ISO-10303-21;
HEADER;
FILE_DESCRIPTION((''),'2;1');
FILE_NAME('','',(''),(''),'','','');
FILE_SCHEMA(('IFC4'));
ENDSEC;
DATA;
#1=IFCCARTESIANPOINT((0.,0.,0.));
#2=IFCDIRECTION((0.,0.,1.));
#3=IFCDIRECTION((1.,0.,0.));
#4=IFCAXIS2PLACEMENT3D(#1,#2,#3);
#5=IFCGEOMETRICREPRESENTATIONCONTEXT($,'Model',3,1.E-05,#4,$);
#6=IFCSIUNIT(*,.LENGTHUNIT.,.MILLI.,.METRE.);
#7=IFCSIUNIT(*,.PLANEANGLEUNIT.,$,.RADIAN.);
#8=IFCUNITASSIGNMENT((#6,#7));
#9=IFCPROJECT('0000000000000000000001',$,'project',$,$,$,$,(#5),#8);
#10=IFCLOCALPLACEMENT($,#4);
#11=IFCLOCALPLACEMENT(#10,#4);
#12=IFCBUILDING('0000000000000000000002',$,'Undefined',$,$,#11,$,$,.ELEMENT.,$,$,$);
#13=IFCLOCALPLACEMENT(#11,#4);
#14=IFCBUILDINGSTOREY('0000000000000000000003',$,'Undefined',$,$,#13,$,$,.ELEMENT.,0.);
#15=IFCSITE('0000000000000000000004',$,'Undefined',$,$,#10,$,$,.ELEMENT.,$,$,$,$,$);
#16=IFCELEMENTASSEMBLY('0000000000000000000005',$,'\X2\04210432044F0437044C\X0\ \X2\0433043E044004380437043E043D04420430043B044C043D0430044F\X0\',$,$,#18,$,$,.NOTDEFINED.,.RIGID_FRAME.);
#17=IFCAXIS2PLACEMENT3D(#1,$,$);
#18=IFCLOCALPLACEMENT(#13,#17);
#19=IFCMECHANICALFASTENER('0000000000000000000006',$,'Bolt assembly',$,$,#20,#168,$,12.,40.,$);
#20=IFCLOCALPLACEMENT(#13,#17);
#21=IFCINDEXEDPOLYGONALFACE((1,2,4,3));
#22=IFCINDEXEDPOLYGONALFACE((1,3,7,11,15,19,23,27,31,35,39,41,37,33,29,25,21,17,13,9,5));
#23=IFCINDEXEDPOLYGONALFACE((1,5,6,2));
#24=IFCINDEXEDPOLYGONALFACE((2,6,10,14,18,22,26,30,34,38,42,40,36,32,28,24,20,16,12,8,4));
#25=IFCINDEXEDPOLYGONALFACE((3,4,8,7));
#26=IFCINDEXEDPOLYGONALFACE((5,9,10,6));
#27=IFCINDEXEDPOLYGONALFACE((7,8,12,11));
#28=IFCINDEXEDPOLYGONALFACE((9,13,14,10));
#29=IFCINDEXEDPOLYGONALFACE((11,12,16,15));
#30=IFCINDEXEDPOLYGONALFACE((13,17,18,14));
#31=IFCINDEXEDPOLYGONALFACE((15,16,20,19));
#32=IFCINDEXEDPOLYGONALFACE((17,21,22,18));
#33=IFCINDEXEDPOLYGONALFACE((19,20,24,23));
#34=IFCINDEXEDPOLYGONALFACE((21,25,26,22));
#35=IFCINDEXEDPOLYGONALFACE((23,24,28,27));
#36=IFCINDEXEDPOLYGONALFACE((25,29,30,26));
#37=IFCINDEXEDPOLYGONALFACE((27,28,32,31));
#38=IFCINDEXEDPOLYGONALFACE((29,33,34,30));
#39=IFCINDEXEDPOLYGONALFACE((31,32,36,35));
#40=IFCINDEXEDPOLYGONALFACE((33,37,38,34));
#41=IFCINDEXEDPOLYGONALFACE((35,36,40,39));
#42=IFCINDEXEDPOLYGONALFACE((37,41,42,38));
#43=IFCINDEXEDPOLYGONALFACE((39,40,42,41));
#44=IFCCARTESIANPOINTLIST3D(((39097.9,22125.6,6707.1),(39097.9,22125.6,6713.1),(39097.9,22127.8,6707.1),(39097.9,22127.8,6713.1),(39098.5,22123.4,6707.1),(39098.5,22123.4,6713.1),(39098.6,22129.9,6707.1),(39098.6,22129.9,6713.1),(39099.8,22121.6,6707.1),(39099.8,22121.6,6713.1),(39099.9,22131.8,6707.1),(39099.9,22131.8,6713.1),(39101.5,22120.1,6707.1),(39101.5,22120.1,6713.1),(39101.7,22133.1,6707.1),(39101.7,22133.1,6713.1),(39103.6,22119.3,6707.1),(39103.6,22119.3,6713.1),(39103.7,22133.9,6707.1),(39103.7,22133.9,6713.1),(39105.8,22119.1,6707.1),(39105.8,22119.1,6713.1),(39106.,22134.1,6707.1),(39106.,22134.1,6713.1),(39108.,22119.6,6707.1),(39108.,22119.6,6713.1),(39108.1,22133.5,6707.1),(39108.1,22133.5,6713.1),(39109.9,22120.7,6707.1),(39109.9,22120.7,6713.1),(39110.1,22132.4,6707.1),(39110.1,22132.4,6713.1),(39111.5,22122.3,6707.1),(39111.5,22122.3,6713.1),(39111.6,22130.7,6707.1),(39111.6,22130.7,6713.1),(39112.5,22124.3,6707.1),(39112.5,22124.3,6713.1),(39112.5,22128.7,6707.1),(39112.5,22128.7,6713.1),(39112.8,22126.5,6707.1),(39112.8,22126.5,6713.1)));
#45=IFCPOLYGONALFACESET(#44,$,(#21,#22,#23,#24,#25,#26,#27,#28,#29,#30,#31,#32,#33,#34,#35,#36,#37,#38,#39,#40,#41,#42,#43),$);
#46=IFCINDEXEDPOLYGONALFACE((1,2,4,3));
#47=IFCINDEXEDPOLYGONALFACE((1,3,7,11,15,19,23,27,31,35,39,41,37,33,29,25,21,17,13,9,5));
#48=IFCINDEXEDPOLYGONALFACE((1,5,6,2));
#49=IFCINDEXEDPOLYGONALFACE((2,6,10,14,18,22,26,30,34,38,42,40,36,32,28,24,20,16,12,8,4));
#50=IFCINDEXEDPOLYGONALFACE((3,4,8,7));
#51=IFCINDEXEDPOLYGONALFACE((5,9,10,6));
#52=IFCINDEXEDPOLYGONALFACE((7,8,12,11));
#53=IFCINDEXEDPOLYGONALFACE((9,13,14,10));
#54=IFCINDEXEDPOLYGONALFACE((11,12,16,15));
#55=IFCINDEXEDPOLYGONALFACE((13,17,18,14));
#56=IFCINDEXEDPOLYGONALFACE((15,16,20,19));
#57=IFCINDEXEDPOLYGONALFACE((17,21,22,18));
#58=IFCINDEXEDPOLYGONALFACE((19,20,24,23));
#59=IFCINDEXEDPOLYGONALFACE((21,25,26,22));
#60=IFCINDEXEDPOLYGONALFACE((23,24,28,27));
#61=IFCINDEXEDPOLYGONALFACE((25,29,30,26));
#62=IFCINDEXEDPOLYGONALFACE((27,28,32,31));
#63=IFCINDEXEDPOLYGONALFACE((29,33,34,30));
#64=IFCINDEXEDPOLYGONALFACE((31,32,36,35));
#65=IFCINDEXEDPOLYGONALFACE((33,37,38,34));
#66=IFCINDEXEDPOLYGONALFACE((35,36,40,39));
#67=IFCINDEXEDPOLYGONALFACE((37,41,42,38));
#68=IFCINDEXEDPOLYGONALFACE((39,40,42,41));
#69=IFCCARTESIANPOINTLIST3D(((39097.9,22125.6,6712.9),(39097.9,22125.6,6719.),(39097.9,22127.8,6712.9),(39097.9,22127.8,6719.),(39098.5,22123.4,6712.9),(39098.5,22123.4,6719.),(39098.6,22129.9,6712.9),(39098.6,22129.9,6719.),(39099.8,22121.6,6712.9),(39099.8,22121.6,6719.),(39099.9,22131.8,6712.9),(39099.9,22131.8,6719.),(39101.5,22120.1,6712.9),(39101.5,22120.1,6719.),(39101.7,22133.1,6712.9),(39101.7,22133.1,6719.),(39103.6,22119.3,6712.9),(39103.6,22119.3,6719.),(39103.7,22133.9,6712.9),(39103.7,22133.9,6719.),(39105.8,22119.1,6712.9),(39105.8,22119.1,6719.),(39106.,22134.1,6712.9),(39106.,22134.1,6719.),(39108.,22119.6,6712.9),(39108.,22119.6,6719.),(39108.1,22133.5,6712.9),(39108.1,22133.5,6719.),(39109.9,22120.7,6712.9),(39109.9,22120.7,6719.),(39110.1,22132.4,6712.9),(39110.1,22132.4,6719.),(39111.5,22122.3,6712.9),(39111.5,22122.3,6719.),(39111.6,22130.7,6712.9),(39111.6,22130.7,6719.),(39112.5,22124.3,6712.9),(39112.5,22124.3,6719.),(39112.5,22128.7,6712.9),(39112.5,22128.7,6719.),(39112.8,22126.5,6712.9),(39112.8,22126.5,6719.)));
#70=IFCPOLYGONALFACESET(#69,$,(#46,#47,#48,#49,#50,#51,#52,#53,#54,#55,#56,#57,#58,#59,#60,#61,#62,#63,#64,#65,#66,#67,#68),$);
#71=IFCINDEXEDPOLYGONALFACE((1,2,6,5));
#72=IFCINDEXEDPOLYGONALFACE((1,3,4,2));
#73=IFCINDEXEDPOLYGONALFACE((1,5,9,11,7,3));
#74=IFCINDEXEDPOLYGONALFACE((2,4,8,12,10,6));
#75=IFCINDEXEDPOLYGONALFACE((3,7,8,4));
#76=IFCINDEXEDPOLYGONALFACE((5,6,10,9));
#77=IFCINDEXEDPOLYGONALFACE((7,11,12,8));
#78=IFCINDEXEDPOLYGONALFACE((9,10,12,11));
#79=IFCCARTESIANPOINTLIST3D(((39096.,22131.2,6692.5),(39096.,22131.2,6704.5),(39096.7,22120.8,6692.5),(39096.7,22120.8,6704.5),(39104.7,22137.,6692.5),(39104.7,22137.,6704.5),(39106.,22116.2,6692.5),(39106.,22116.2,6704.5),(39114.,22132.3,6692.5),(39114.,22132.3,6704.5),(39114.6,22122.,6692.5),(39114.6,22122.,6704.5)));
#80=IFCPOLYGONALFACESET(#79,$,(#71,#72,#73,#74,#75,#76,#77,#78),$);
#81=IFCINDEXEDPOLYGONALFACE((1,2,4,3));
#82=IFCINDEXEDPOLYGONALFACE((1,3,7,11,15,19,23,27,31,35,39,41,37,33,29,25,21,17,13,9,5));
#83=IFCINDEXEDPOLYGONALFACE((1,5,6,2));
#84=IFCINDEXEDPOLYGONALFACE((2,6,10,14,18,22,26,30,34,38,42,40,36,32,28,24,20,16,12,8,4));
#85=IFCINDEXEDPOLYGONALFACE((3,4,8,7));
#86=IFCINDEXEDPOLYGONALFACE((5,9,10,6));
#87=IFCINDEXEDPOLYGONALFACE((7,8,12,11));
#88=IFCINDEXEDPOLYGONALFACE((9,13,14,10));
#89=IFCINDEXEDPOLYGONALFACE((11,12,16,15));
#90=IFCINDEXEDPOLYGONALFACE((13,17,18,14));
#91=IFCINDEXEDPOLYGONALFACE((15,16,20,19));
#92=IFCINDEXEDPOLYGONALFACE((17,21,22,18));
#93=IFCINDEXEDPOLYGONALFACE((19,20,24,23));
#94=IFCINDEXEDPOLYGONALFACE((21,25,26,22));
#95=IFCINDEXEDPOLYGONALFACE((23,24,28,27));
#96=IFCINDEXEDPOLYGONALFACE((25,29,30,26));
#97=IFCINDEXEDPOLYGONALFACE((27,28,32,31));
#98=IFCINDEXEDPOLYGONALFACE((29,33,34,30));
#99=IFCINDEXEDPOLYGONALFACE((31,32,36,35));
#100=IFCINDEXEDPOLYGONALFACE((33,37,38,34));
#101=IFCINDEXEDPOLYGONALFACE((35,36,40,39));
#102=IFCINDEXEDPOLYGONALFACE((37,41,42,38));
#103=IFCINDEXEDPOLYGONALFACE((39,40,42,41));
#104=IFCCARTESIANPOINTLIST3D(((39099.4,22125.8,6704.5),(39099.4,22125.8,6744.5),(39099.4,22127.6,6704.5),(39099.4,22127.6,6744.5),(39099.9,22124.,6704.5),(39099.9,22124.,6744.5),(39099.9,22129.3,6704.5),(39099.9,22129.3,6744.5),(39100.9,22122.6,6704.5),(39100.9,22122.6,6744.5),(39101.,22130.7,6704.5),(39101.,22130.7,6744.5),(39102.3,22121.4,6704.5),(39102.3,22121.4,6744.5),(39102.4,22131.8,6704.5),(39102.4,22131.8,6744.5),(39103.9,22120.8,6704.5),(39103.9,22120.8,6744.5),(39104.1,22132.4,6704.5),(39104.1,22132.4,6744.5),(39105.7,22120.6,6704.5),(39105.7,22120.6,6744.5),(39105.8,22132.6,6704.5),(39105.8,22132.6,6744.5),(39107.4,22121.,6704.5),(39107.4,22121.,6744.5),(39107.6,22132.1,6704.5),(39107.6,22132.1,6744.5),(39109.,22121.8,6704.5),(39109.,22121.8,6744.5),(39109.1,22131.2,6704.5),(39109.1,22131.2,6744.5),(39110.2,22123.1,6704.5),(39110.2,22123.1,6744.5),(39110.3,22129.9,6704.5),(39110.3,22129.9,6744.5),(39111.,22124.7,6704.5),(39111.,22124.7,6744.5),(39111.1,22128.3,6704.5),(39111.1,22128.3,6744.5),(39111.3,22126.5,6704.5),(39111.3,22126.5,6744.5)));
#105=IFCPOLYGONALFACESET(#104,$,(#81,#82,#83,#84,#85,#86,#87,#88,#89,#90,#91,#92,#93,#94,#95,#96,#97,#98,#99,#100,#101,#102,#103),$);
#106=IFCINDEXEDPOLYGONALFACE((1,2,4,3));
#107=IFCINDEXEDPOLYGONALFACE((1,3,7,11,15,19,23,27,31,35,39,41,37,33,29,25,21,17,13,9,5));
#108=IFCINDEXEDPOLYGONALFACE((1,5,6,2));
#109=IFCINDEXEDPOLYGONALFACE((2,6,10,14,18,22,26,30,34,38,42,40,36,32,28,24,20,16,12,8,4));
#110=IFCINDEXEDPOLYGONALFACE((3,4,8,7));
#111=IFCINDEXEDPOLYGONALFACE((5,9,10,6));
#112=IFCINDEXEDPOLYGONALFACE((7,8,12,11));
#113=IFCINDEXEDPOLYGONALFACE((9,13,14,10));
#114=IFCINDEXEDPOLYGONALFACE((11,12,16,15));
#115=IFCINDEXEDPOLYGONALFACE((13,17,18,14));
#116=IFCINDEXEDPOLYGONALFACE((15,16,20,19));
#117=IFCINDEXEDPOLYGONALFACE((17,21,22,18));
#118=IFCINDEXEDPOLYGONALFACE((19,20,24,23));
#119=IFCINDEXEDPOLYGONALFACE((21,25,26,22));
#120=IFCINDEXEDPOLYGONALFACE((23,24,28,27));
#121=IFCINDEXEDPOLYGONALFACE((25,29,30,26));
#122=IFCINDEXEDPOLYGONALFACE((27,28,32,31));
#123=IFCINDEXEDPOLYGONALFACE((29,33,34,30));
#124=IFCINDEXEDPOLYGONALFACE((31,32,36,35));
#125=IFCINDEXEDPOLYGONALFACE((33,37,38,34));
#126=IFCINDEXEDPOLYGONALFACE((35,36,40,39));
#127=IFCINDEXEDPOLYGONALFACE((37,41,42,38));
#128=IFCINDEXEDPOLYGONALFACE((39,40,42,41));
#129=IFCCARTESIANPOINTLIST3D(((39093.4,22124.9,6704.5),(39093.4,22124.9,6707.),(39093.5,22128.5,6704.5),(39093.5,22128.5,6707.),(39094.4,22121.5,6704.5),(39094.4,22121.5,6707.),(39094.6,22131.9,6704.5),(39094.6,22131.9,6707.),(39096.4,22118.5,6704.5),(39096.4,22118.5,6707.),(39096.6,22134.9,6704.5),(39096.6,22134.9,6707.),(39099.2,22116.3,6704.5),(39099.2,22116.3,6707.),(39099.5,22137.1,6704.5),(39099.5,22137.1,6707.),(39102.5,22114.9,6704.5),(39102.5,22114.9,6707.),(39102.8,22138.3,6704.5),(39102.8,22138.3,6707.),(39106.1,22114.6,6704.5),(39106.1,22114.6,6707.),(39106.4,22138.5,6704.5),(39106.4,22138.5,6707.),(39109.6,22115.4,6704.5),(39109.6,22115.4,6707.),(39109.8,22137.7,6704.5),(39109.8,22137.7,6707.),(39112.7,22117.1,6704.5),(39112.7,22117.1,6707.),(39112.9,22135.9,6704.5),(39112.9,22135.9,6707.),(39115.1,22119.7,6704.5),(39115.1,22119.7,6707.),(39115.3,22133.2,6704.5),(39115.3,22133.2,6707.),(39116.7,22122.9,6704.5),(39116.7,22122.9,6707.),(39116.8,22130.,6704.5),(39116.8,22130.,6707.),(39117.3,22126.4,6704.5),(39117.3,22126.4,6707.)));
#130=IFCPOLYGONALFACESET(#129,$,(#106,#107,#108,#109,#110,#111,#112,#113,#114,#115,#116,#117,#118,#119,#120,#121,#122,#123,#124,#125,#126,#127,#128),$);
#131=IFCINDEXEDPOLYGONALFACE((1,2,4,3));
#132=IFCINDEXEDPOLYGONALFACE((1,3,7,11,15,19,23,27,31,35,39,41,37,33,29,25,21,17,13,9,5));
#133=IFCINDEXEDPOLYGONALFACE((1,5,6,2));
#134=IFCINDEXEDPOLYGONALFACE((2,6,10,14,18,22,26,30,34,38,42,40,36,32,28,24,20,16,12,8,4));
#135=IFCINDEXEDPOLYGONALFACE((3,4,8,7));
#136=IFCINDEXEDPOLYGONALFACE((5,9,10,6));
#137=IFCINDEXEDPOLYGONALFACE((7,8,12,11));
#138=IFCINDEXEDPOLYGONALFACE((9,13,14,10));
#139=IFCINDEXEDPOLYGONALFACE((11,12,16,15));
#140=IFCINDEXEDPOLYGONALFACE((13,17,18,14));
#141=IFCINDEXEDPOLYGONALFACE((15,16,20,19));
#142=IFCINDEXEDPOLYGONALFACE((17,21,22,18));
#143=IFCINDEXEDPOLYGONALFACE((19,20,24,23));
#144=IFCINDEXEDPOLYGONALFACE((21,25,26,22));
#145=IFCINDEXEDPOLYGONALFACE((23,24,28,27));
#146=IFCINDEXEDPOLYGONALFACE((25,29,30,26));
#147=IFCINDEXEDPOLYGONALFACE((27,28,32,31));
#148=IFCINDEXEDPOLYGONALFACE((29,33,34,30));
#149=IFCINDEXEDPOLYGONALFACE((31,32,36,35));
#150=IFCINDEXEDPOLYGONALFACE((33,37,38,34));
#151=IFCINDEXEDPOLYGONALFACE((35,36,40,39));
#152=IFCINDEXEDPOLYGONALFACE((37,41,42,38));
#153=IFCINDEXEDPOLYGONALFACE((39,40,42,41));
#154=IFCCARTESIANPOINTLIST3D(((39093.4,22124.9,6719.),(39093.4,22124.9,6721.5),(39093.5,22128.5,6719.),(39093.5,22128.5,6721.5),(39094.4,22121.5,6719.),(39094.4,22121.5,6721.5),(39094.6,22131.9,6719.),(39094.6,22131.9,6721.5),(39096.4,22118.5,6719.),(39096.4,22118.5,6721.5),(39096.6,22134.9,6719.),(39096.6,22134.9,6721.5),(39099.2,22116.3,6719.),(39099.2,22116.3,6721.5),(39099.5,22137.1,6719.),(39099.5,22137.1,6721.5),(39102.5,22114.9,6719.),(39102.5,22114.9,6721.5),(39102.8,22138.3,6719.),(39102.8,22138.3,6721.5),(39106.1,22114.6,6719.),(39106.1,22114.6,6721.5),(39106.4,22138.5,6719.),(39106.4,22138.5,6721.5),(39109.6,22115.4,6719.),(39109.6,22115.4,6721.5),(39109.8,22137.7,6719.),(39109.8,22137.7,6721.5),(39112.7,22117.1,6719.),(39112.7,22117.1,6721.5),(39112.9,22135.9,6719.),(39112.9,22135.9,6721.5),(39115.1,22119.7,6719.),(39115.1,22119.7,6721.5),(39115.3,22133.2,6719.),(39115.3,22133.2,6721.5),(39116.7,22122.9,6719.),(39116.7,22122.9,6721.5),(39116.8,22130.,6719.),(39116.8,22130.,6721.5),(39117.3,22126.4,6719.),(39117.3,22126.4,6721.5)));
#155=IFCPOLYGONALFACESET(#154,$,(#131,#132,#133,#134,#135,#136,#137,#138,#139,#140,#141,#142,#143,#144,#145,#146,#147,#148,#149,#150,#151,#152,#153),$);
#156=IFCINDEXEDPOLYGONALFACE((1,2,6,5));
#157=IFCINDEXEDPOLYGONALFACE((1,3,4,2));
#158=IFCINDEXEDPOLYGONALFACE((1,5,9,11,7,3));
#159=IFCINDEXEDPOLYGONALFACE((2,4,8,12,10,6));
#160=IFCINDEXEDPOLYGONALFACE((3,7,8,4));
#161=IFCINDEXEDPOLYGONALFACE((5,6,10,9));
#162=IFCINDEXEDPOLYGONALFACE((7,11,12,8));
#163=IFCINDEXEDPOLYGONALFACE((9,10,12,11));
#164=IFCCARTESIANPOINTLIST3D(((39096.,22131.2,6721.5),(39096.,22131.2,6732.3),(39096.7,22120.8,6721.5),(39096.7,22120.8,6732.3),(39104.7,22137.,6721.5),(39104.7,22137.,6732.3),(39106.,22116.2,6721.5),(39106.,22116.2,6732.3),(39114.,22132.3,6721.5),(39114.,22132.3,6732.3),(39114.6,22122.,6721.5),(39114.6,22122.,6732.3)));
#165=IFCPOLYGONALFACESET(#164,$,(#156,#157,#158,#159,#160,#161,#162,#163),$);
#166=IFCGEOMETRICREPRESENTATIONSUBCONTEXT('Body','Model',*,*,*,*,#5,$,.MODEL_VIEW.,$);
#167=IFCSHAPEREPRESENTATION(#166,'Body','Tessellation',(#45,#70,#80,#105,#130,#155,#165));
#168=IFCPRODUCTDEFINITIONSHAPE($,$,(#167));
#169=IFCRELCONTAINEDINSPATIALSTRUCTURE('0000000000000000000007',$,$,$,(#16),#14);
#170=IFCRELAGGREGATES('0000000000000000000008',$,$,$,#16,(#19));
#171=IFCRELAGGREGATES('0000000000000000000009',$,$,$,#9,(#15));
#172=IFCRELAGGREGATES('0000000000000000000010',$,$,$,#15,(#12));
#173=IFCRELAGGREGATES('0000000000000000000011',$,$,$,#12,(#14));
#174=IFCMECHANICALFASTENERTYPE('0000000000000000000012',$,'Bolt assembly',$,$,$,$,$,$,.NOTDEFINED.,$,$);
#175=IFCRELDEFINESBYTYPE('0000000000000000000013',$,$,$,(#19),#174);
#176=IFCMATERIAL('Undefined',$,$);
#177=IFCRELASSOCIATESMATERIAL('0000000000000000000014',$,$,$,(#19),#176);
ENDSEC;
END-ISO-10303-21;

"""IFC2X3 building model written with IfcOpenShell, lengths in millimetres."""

from ifc_helpers import new_model, si_unit, frame, origin_with_axes, origin_2d_with_axis, place, context, subcontext, project, spatial, polyline, circle, outline, extrude, source, transform, mapped, material, type_object, element, aggregate, save


model = new_model("IFC2X3")

# Units and contexts
model_context = context("Model", 3, precision=1e-05, world=origin_with_axes())
body_context = subcontext(model_context, "Body", "Model", "MODEL_VIEW")
ifc_project = project(units=[si_unit("LENGTHUNIT", "METRE", prefix="MILLI"), si_unit("PLANEANGLEUNIT", "RADIAN")], contexts=[model_context])

# Site, building, storey
site_placement = place(None, origin_with_axes())
site = spatial("IfcSite", under=ifc_project, at=site_placement, Name="Undefined", CompositionType="ELEMENT")
building_placement = place(site_placement, origin_with_axes())
building = spatial("IfcBuilding", under=site, at=building_placement, Name="Undefined", CompositionType="ELEMENT")
storey_placement = place(building_placement, origin_with_axes())
storey = spatial("IfcBuildingStorey", under=building, at=storey_placement, Name="Undefined", CompositionType="ELEMENT", Elevation=0.0)

# Element assembly
assembly_1_placement = place(storey_placement, origin_with_axes())
assembly_1 = element("IfcElementAssembly", 1, at=assembly_1_placement, inside=storey, Name="Связь горизонтальная", AssemblyPlace="NOTDEFINED", PredefinedType="RIGID_FRAME")

# Mechanical fastener
ifc_material_1 = material(Name="Undefined")
mechanical_fastener_type = type_object("IfcMechanicalFastenerType", Name="Bolt assembly")
shared_shape_1 = source(origin_with_axes(), body_context, "Body", "SweptSolid", [
    extrude(circle(Radius=7.5, at=origin_2d_with_axis()), frame((0.0, 0.1, 0.0), z_axis=(0.0, 1.0, 0.0), x_axis=(1.0, 0.0, 0.0)), (0.0, 0.0, 1.0), 6.0),
    extrude(circle(Radius=7.5, at=origin_2d_with_axis()), frame((0.0, 5.9, 0.0), z_axis=(0.0, 1.0, 0.0), x_axis=(1.0, 0.0, 0.0)), (0.0, 0.0, 1.0), 6.1),
    extrude(outline(polyline([(10.4, 0.0), (5.2, 9.0), (-5.2, 9.0), (-10.4, 0.0), (-5.2, -9.0), (5.2, -9.0), (10.4, 0.0)])), frame((0.0, -14.5, 0.0), z_axis=(0.0, 1.0, 0.0), x_axis=(1.0, 0.0, 0.0)), (0.0, 0.0, 1.0), 12.0),
    extrude(circle(Radius=6.0, at=origin_2d_with_axis()), frame((0.0, -2.5, 0.0), z_axis=(0.0, 1.0, 0.0), x_axis=(1.0, 0.0, 0.0)), (0.0, 0.0, 1.0), 40.0),
    extrude(circle(Radius=12.0, at=origin_2d_with_axis()), frame((0.0, -2.5, 0.0), z_axis=(0.0, 1.0, 0.0), x_axis=(1.0, 0.0, 0.0)), (0.0, 0.0, 1.0), 2.5),
    extrude(circle(Radius=12.0, at=origin_2d_with_axis()), frame((0.0, 12.0, 0.0), z_axis=(0.0, 1.0, 0.0), x_axis=(1.0, 0.0, 0.0)), (0.0, 0.0, 1.0), 2.5),
    extrude(outline(polyline([(10.4, 0.0), (5.2, 9.0), (-5.2, 9.0), (-10.4, 0.0), (-5.2, -9.0), (5.2, -9.0), (10.4, 0.0)])), frame((0.0, 14.5, 0.0), z_axis=(0.0, 1.0, 0.0), x_axis=(1.0, 0.0, 0.0)), (0.0, 0.0, 1.0), 10.8),
])
mechanical_fastener_1_placement = place(assembly_1_placement, frame((39105.3, 22126.6, 6707.0), z_axis=(0.552695, -0.833383, 0.0), x_axis=(0.833383, 0.552695, 0.0)))
mechanical_fastener_1 = element("IfcMechanicalFastener", 2, at=mechanical_fastener_1_placement, type_object=mechanical_fastener_type, material=ifc_material_1, Name="Bolt assembly", NominalDiameter=12.0, NominalLength=40.0, context=body_context, shape_type="MappedRepresentation", body=[
    mapped(shared_shape_1, transform((0.0, 0.0, 0.0))),
])
aggregate(assembly_1, [mechanical_fastener_1])

save(model, "model.ifc")
